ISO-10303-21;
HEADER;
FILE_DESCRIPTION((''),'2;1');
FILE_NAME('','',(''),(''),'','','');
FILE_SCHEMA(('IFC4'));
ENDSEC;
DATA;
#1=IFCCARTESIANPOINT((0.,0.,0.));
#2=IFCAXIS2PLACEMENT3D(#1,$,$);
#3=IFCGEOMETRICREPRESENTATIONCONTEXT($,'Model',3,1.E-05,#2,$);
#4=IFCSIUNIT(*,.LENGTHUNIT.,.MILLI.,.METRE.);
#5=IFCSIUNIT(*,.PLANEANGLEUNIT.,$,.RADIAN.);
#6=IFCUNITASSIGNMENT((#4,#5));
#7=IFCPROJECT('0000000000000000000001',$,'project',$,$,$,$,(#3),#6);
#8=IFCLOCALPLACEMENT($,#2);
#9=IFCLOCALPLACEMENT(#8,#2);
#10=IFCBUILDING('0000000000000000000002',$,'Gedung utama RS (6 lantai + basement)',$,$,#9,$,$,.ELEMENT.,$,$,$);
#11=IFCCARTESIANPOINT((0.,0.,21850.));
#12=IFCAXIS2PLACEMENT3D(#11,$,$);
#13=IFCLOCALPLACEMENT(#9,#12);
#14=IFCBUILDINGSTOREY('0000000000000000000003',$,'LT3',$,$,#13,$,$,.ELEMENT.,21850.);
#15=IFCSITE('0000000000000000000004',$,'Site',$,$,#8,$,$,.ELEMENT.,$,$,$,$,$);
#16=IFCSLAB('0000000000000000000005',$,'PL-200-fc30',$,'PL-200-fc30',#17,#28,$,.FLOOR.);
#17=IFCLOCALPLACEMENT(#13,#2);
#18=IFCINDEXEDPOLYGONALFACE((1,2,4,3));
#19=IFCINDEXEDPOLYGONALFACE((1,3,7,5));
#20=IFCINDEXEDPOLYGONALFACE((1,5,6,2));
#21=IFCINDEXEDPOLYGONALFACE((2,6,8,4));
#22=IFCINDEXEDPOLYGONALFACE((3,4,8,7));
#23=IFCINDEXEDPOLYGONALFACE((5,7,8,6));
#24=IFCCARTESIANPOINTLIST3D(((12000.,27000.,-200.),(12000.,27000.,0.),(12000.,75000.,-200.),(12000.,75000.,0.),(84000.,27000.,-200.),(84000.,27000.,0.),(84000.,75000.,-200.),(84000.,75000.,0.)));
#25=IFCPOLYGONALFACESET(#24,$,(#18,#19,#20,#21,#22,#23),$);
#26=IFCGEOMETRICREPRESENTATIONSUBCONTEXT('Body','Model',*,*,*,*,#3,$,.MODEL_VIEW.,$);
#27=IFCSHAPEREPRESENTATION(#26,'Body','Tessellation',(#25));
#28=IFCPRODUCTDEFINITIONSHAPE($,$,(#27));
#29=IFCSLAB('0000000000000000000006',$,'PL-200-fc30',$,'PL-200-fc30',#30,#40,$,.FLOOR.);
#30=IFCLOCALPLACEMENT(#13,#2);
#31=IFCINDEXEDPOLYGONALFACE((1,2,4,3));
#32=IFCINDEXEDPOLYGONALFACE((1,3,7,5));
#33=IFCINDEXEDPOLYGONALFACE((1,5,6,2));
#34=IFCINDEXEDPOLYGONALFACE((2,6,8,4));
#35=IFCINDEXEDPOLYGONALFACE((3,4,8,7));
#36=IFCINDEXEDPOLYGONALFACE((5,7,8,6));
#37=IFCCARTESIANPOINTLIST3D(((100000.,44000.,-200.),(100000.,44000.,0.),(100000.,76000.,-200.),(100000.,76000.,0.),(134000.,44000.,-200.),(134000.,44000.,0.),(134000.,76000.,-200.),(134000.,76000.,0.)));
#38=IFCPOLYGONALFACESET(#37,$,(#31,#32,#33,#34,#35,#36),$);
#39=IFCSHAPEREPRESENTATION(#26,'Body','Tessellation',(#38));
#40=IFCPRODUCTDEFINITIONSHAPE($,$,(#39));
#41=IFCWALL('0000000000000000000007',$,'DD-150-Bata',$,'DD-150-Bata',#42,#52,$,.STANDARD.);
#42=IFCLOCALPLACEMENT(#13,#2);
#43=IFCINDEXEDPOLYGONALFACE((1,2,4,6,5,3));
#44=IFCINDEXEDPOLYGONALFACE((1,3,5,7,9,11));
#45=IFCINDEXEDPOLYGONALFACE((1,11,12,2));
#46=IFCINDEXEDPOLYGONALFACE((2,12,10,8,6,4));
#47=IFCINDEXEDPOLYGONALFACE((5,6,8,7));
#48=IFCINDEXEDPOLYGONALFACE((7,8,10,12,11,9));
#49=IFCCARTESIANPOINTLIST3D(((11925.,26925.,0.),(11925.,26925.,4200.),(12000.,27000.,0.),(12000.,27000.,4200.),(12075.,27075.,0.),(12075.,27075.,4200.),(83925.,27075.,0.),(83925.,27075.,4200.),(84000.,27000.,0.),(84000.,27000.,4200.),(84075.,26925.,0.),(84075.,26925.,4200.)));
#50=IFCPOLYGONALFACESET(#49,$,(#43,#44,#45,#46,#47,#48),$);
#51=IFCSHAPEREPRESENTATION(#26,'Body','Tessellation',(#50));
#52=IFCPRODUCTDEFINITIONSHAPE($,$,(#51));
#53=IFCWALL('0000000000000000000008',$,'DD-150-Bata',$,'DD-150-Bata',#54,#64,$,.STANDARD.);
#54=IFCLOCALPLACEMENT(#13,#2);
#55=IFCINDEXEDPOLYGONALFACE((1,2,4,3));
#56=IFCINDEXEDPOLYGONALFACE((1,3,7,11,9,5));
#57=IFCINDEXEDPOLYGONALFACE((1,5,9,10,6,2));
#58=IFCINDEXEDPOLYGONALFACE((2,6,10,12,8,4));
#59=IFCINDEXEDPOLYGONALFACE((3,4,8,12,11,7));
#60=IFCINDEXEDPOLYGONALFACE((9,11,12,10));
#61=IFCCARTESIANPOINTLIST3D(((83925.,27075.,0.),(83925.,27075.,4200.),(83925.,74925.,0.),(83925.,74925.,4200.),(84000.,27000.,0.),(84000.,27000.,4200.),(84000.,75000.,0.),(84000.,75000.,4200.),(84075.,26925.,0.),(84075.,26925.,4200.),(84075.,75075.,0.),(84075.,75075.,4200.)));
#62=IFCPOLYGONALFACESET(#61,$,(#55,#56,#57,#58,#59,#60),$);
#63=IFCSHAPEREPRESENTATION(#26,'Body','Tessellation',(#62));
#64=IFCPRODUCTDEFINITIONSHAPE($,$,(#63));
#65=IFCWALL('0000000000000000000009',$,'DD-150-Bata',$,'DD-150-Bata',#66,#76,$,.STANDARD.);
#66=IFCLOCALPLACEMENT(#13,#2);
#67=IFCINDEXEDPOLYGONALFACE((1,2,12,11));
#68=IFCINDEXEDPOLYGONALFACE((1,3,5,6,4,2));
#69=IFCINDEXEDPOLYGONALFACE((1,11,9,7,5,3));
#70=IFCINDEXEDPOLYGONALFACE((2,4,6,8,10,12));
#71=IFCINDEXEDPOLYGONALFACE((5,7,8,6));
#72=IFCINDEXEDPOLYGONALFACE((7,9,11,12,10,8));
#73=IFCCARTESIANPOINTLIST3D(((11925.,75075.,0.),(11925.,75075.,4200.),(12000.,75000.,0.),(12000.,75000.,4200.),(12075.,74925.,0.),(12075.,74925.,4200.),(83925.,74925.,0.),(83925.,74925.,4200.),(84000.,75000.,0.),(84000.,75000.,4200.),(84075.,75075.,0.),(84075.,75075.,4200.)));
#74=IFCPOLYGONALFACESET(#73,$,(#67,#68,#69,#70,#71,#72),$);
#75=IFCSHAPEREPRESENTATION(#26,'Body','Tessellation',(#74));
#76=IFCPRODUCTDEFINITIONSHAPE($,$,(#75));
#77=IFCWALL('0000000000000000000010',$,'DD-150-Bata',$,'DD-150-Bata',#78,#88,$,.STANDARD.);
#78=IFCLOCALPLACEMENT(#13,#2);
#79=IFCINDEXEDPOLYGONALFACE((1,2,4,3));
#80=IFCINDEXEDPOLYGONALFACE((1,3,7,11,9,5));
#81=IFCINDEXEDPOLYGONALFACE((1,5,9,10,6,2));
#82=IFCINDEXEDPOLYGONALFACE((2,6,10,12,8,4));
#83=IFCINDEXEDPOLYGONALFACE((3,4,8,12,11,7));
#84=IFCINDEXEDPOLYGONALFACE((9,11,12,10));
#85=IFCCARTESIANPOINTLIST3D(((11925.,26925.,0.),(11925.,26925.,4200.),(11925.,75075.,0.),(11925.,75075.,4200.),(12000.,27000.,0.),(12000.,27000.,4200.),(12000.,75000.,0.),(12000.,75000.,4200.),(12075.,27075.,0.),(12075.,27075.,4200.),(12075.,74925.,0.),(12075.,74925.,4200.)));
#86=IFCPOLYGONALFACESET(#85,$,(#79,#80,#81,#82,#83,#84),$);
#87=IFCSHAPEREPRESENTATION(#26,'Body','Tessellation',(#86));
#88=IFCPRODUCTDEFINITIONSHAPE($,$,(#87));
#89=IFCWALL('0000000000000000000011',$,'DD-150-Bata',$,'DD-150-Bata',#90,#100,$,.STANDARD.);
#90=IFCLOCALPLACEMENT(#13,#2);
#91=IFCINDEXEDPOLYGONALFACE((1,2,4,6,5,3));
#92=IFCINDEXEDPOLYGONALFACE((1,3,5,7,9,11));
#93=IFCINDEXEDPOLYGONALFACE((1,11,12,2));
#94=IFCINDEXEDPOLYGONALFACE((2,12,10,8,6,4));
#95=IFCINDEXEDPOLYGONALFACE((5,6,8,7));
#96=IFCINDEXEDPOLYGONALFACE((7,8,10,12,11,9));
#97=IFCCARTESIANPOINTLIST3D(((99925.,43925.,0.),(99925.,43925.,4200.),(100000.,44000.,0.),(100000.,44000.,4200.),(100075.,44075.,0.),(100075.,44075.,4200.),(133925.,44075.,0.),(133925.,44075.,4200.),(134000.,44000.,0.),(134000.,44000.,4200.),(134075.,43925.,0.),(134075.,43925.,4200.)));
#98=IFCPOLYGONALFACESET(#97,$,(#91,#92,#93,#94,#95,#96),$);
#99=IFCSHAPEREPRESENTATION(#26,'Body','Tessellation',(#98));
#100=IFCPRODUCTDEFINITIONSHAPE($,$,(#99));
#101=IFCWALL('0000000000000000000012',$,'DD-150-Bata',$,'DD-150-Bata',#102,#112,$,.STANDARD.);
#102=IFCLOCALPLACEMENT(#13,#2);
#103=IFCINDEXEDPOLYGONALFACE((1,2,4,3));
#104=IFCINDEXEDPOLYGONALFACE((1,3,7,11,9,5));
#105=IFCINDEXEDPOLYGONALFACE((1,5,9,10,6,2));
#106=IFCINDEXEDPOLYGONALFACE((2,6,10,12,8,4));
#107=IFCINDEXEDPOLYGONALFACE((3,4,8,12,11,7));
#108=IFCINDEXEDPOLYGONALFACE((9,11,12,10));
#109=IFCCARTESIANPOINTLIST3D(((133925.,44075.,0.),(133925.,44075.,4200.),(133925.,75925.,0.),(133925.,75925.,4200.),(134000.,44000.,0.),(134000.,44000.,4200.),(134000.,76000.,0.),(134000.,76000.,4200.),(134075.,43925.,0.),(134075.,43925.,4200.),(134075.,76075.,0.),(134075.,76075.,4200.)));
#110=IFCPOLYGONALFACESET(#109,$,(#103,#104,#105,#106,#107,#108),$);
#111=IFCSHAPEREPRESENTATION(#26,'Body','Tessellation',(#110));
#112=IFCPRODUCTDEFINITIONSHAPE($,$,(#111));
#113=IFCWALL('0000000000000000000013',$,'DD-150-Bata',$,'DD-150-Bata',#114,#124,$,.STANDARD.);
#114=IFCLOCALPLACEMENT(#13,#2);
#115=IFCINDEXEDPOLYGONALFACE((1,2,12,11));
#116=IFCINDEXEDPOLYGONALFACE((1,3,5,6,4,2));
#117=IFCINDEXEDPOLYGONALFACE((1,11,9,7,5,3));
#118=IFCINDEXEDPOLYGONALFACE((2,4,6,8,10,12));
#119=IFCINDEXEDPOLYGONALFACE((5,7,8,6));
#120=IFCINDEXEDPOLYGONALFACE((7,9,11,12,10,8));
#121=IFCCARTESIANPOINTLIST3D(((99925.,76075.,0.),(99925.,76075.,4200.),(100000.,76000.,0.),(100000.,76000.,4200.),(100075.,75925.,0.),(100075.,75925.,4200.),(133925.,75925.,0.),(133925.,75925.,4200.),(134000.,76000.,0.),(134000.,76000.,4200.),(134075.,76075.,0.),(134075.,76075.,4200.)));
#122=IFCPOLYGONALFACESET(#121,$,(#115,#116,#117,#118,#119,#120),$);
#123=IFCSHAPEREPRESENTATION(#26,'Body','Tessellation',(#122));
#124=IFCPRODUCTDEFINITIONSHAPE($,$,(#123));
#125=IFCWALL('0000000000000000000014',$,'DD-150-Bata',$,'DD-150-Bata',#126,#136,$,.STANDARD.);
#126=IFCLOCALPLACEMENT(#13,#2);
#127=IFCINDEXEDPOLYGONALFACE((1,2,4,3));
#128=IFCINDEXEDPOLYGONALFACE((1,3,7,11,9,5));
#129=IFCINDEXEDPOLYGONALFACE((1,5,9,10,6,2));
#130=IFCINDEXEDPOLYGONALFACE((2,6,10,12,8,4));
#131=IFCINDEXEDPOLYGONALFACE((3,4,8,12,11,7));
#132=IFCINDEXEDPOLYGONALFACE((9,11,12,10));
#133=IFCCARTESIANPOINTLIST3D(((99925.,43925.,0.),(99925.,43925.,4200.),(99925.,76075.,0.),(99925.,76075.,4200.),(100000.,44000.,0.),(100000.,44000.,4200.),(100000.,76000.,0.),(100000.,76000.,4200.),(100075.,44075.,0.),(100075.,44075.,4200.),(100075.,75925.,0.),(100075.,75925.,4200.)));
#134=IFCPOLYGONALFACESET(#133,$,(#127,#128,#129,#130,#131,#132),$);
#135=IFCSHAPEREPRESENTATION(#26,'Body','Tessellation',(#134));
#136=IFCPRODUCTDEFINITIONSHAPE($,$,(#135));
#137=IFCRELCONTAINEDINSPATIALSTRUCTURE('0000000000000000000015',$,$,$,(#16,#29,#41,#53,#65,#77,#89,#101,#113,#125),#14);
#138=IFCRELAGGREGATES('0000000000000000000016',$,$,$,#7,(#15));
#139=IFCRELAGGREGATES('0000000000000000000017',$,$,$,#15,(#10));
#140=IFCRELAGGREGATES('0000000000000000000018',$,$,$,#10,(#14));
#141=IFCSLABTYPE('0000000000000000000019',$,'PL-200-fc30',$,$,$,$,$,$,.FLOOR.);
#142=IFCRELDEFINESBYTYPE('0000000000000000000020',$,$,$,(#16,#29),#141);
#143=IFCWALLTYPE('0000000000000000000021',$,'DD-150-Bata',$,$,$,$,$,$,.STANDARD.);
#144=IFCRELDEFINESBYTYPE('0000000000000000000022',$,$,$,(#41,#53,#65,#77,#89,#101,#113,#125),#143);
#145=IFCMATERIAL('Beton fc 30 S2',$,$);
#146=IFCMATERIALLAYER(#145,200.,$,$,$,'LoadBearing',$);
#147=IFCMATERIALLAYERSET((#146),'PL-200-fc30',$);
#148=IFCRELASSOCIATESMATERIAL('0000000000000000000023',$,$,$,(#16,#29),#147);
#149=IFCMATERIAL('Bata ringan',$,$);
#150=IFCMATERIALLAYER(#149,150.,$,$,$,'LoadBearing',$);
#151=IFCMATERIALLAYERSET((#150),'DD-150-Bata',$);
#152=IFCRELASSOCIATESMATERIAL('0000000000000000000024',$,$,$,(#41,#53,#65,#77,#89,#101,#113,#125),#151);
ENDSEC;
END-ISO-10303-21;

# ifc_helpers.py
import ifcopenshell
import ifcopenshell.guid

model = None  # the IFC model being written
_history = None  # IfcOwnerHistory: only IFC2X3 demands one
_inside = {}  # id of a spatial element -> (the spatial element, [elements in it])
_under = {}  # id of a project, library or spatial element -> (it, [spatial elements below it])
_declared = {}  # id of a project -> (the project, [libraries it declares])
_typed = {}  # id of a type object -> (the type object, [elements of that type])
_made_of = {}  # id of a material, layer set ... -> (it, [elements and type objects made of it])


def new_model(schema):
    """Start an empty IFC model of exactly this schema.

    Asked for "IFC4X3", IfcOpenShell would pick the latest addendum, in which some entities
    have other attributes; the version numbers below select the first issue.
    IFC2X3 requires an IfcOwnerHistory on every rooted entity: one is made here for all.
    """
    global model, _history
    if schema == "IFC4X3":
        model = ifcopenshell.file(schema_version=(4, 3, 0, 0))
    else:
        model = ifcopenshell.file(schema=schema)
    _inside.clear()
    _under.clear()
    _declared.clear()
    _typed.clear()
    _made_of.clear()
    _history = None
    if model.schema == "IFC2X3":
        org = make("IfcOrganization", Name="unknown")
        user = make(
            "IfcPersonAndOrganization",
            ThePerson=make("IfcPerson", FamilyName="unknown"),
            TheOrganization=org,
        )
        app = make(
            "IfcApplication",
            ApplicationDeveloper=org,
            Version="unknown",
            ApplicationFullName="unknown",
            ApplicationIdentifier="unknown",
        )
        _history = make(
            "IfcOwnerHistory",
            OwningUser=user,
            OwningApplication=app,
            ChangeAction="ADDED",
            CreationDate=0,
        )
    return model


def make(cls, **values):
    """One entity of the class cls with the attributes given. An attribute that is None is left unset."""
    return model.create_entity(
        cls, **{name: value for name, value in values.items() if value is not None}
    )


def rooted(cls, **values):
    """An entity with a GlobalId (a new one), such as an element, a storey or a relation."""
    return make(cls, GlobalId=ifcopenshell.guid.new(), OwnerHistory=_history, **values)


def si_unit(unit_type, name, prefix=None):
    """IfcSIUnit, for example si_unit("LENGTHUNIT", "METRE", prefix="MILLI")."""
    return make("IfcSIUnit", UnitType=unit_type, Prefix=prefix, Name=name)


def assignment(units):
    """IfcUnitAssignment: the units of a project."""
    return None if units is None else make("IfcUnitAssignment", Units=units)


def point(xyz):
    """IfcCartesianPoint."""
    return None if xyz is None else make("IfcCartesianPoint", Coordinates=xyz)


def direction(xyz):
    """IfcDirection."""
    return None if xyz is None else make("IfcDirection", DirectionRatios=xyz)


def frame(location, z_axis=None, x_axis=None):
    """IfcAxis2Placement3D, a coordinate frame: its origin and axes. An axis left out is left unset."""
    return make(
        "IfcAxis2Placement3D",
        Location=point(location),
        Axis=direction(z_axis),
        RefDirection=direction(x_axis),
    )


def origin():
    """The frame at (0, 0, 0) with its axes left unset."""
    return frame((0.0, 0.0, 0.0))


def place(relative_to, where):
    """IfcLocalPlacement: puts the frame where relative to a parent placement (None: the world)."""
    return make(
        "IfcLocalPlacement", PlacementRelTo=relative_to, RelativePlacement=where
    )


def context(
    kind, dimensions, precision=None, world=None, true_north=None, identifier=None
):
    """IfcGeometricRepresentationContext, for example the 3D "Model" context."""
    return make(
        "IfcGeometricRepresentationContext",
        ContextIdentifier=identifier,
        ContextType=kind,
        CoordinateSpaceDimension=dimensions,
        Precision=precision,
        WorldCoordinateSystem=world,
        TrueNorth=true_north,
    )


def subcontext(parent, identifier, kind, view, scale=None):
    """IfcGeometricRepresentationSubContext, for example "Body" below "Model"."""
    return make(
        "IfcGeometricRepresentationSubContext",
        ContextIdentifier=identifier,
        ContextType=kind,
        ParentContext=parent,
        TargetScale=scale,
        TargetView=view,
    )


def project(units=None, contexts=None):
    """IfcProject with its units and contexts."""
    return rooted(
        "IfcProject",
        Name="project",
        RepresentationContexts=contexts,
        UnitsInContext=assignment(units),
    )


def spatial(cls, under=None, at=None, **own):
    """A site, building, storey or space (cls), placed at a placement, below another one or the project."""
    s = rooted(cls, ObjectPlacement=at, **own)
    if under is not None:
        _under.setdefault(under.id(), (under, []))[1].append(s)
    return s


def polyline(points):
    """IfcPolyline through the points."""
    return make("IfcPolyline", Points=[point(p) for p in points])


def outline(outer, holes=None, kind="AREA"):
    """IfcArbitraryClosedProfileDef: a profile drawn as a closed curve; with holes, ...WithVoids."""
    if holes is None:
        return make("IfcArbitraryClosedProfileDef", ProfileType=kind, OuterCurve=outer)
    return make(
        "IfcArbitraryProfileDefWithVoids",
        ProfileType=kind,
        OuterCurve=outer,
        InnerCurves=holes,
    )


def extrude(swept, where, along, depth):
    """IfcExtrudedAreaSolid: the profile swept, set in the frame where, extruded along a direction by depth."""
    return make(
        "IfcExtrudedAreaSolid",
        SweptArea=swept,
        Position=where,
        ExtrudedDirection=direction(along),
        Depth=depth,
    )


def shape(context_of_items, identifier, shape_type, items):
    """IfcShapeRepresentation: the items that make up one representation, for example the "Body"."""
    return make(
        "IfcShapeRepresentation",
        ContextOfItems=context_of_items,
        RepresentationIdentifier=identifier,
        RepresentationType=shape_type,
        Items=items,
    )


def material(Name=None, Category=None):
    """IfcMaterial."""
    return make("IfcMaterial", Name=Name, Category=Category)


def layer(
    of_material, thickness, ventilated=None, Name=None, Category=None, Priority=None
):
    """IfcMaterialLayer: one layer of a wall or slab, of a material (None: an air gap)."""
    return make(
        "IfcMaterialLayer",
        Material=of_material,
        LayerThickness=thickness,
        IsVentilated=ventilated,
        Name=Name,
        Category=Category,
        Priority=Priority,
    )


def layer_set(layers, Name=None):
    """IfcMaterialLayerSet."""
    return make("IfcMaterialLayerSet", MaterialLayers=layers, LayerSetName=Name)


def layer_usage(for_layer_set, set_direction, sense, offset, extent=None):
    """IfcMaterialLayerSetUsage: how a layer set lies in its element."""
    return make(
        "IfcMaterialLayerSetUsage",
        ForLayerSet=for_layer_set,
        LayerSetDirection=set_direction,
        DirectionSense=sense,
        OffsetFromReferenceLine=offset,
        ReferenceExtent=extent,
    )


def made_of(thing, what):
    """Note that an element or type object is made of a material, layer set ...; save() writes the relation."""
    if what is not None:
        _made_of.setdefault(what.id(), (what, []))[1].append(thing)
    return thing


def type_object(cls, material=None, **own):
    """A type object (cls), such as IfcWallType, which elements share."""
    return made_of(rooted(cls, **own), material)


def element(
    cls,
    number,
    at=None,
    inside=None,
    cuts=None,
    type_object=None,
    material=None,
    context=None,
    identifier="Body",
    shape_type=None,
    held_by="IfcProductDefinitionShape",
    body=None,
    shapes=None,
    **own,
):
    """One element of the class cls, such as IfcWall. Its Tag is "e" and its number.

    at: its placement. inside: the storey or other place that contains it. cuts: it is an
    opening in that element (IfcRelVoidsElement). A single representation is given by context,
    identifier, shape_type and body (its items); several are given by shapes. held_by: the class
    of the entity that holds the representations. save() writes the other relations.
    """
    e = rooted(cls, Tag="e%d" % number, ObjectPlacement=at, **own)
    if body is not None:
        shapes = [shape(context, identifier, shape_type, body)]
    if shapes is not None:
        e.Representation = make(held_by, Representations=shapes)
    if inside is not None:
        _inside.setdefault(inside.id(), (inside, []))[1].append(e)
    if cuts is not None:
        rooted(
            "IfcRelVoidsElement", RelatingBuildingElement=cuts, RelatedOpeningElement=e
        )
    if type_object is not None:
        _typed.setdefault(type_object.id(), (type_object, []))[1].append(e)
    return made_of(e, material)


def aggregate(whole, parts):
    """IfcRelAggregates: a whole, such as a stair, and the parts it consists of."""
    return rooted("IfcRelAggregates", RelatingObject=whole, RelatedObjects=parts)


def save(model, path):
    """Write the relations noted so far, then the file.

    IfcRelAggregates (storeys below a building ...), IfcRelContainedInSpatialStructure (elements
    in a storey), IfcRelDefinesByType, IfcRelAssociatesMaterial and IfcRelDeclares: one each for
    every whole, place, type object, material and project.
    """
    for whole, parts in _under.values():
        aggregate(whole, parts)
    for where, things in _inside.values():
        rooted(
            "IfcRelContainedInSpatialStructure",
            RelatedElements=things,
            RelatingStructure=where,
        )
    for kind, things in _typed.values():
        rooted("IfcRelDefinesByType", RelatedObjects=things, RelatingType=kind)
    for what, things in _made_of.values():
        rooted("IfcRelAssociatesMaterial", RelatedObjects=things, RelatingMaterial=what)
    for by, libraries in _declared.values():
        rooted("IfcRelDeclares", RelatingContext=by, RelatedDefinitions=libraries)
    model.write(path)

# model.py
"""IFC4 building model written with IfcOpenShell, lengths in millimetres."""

from ifc_helpers import new_model, si_unit, frame, origin, place, context, subcontext, project, spatial, polyline, outline, extrude, material, layer, layer_set, layer_usage, type_object, element, save


model = new_model("IFC4")

# Units and contexts
model_context = context("Model", 3, precision=1e-05, world=origin())
body_context = subcontext(model_context, "Body", "Model", "MODEL_VIEW")
ifc_project = project(units=[si_unit("LENGTHUNIT", "METRE", prefix="MILLI"), si_unit("PLANEANGLEUNIT", "RADIAN")], contexts=[model_context])

# Site, building, storey
site_placement = place(None, origin())
site = spatial("IfcSite", under=ifc_project, at=site_placement, Name="Site", CompositionType="ELEMENT")
building_placement = place(site_placement, origin())
building = spatial("IfcBuilding", under=site, at=building_placement, Name="Gedung utama RS (6 lantai + basement)", CompositionType="ELEMENT")
storey_placement = place(building_placement, frame((0.0, 0.0, 21850.0)))
storey = spatial("IfcBuildingStorey", under=building, at=storey_placement, Name="LT3", CompositionType="ELEMENT", Elevation=21850.0)

# Slabs
ifc_material_1 = material(Name="Beton fc 30 S2")
ifc_layer_1 = layer(ifc_material_1, 200.0, Category="LoadBearing")
ifc_layer_set_1 = layer_set([ifc_layer_1], Name="PL-200-fc30")
ifc_layer_usage_1 = layer_usage(ifc_layer_set_1, "AXIS3", "NEGATIVE", 0.0)
slab_type = type_object("IfcSlabType", Name="PL-200-fc30", PredefinedType="FLOOR")
slab_1_placement = place(storey_placement, origin())
element("IfcSlab", 1, at=slab_1_placement, inside=storey, type_object=slab_type, material=ifc_layer_usage_1, Name="PL-200-fc30", ObjectType="PL-200-fc30", PredefinedType="FLOOR", context=body_context, shape_type="SweptSolid", body=[
    extrude(outline(polyline([(12000.0, 27000.0), (84000.0, 27000.0), (84000.0, 75000.0), (12000.0, 75000.0), (12000.0, 27000.0)])), frame((0.0, 0.0, -200.0)), (0.0, 0.0, 1.0), 200.0),
])
slab_2_placement = place(storey_placement, origin())
element("IfcSlab", 2, at=slab_2_placement, inside=storey, type_object=slab_type, material=ifc_layer_usage_1, Name="PL-200-fc30", ObjectType="PL-200-fc30", PredefinedType="FLOOR", context=body_context, shape_type="SweptSolid", body=[
    extrude(outline(polyline([(100000.0, 44000.0), (134000.0, 44000.0), (134000.0, 76000.0), (100000.0, 76000.0), (100000.0, 44000.0)])), frame((0.0, 0.0, -200.0)), (0.0, 0.0, 1.0), 200.0),
])

# Walls
ifc_material_2 = material(Name="Bata ringan")
ifc_layer_2 = layer(ifc_material_2, 150.0, Category="LoadBearing")
ifc_layer_set_2 = layer_set([ifc_layer_2], Name="DD-150-Bata")
ifc_layer_usage_2 = layer_usage(ifc_layer_set_2, "AXIS2", "NEGATIVE", 75.0)
wall_type = type_object("IfcWallType", Name="DD-150-Bata", PredefinedType="STANDARD")
wall_1_placement = place(storey_placement, frame((12000.0, 27000.0, 0.0), z_axis=(0.0, 0.0, 1.0), x_axis=(1.0, 0.0, 0.0)))
element("IfcWall", 3, at=wall_1_placement, inside=storey, type_object=wall_type, material=ifc_layer_usage_2, Name="DD-150-Bata", ObjectType="DD-150-Bata", PredefinedType="STANDARD", context=body_context, shape_type="SweptSolid", body=[
    extrude(outline(polyline([(-75.0, -75.0), (0.0, 0.0), (75.0, 75.0), (71925.0, 75.0), (72000.0, 0.0), (72075.0, -75.0), (-75.0, -75.0)])), origin(), (0.0, 0.0, 1.0), 4200.0),
])
wall_2_placement = place(storey_placement, frame((84000.0, 27000.0, 0.0), z_axis=(0.0, 0.0, 1.0), x_axis=(0.0, 1.0, 0.0)))
element("IfcWall", 4, at=wall_2_placement, inside=storey, type_object=wall_type, material=ifc_layer_usage_2, Name="DD-150-Bata", ObjectType="DD-150-Bata", PredefinedType="STANDARD", context=body_context, shape_type="SweptSolid", body=[
    extrude(outline(polyline([(-75.0, -75.0), (0.0, 0.0), (75.0, 75.0), (47925.0, 75.0), (48000.0, 0.0), (48075.0, -75.0), (-75.0, -75.0)])), origin(), (0.0, 0.0, 1.0), 4200.0),
])
wall_3_placement = place(storey_placement, frame((84000.0, 75000.0, 0.0), z_axis=(0.0, 0.0, 1.0), x_axis=(-1.0, 0.0, 0.0)))
element("IfcWall", 5, at=wall_3_placement, inside=storey, type_object=wall_type, material=ifc_layer_usage_2, Name="DD-150-Bata", ObjectType="DD-150-Bata", PredefinedType="STANDARD", context=body_context, shape_type="SweptSolid", body=[
    extrude(outline(polyline([(-75.0, -75.0), (0.0, 0.0), (75.0, 75.0), (71925.0, 75.0), (72000.0, 0.0), (72075.0, -75.0), (-75.0, -75.0)])), origin(), (0.0, 0.0, 1.0), 4200.0),
])
wall_4_placement = place(storey_placement, frame((12000.0, 75000.0, 0.0), z_axis=(0.0, 0.0, 1.0), x_axis=(0.0, -1.0, 0.0)))
element("IfcWall", 6, at=wall_4_placement, inside=storey, type_object=wall_type, material=ifc_layer_usage_2, Name="DD-150-Bata", ObjectType="DD-150-Bata", PredefinedType="STANDARD", context=body_context, shape_type="SweptSolid", body=[
    extrude(outline(polyline([(-75.0, -75.0), (0.0, 0.0), (75.0, 75.0), (47925.0, 75.0), (48000.0, 0.0), (48075.0, -75.0), (-75.0, -75.0)])), origin(), (0.0, 0.0, 1.0), 4200.0),
])
wall_5_placement = place(storey_placement, frame((100000.0, 44000.0, 0.0), z_axis=(0.0, 0.0, 1.0), x_axis=(1.0, 0.0, 0.0)))
element("IfcWall", 7, at=wall_5_placement, inside=storey, type_object=wall_type, material=ifc_layer_usage_2, Name="DD-150-Bata", ObjectType="DD-150-Bata", PredefinedType="STANDARD", context=body_context, shape_type="SweptSolid", body=[
    extrude(outline(polyline([(-75.0, -75.0), (0.0, 0.0), (75.0, 75.0), (33925.0, 75.0), (34000.0, 0.0), (34075.0, -75.0), (-75.0, -75.0)])), origin(), (0.0, 0.0, 1.0), 4200.0),
])
wall_6_placement = place(storey_placement, frame((134000.0, 44000.0, 0.0), z_axis=(0.0, 0.0, 1.0), x_axis=(0.0, 1.0, 0.0)))
element("IfcWall", 8, at=wall_6_placement, inside=storey, type_object=wall_type, material=ifc_layer_usage_2, Name="DD-150-Bata", ObjectType="DD-150-Bata", PredefinedType="STANDARD", context=body_context, shape_type="SweptSolid", body=[
    extrude(outline(polyline([(-75.0, -75.0), (0.0, 0.0), (75.0, 75.0), (31925.0, 75.0), (32000.0, 0.0), (32075.0, -75.0), (-75.0, -75.0)])), origin(), (0.0, 0.0, 1.0), 4200.0),
])
wall_7_placement = place(storey_placement, frame((134000.0, 76000.0, 0.0), z_axis=(0.0, 0.0, 1.0), x_axis=(-1.0, 0.0, 0.0)))
element("IfcWall", 9, at=wall_7_placement, inside=storey, type_object=wall_type, material=ifc_layer_usage_2, Name="DD-150-Bata", ObjectType="DD-150-Bata", PredefinedType="STANDARD", context=body_context, shape_type="SweptSolid", body=[
    extrude(outline(polyline([(-75.0, -75.0), (0.0, 0.0), (75.0, 75.0), (33925.0, 75.0), (34000.0, 0.0), (34075.0, -75.0), (-75.0, -75.0)])), origin(), (0.0, 0.0, 1.0), 4200.0),
])
wall_8_placement = place(storey_placement, frame((100000.0, 76000.0, 0.0), z_axis=(0.0, 0.0, 1.0), x_axis=(0.0, -1.0, 0.0)))
element("IfcWall", 10, at=wall_8_placement, inside=storey, type_object=wall_type, material=ifc_layer_usage_2, Name="DD-150-Bata", ObjectType="DD-150-Bata", PredefinedType="STANDARD", context=body_context, shape_type="SweptSolid", body=[
    extrude(outline(polyline([(-75.0, -75.0), (0.0, 0.0), (75.0, 75.0), (31925.0, 75.0), (32000.0, 0.0), (32075.0, -75.0), (-75.0, -75.0)])), origin(), (0.0, 0.0, 1.0), 4200.0),
])

save(model, "model.ifc")
